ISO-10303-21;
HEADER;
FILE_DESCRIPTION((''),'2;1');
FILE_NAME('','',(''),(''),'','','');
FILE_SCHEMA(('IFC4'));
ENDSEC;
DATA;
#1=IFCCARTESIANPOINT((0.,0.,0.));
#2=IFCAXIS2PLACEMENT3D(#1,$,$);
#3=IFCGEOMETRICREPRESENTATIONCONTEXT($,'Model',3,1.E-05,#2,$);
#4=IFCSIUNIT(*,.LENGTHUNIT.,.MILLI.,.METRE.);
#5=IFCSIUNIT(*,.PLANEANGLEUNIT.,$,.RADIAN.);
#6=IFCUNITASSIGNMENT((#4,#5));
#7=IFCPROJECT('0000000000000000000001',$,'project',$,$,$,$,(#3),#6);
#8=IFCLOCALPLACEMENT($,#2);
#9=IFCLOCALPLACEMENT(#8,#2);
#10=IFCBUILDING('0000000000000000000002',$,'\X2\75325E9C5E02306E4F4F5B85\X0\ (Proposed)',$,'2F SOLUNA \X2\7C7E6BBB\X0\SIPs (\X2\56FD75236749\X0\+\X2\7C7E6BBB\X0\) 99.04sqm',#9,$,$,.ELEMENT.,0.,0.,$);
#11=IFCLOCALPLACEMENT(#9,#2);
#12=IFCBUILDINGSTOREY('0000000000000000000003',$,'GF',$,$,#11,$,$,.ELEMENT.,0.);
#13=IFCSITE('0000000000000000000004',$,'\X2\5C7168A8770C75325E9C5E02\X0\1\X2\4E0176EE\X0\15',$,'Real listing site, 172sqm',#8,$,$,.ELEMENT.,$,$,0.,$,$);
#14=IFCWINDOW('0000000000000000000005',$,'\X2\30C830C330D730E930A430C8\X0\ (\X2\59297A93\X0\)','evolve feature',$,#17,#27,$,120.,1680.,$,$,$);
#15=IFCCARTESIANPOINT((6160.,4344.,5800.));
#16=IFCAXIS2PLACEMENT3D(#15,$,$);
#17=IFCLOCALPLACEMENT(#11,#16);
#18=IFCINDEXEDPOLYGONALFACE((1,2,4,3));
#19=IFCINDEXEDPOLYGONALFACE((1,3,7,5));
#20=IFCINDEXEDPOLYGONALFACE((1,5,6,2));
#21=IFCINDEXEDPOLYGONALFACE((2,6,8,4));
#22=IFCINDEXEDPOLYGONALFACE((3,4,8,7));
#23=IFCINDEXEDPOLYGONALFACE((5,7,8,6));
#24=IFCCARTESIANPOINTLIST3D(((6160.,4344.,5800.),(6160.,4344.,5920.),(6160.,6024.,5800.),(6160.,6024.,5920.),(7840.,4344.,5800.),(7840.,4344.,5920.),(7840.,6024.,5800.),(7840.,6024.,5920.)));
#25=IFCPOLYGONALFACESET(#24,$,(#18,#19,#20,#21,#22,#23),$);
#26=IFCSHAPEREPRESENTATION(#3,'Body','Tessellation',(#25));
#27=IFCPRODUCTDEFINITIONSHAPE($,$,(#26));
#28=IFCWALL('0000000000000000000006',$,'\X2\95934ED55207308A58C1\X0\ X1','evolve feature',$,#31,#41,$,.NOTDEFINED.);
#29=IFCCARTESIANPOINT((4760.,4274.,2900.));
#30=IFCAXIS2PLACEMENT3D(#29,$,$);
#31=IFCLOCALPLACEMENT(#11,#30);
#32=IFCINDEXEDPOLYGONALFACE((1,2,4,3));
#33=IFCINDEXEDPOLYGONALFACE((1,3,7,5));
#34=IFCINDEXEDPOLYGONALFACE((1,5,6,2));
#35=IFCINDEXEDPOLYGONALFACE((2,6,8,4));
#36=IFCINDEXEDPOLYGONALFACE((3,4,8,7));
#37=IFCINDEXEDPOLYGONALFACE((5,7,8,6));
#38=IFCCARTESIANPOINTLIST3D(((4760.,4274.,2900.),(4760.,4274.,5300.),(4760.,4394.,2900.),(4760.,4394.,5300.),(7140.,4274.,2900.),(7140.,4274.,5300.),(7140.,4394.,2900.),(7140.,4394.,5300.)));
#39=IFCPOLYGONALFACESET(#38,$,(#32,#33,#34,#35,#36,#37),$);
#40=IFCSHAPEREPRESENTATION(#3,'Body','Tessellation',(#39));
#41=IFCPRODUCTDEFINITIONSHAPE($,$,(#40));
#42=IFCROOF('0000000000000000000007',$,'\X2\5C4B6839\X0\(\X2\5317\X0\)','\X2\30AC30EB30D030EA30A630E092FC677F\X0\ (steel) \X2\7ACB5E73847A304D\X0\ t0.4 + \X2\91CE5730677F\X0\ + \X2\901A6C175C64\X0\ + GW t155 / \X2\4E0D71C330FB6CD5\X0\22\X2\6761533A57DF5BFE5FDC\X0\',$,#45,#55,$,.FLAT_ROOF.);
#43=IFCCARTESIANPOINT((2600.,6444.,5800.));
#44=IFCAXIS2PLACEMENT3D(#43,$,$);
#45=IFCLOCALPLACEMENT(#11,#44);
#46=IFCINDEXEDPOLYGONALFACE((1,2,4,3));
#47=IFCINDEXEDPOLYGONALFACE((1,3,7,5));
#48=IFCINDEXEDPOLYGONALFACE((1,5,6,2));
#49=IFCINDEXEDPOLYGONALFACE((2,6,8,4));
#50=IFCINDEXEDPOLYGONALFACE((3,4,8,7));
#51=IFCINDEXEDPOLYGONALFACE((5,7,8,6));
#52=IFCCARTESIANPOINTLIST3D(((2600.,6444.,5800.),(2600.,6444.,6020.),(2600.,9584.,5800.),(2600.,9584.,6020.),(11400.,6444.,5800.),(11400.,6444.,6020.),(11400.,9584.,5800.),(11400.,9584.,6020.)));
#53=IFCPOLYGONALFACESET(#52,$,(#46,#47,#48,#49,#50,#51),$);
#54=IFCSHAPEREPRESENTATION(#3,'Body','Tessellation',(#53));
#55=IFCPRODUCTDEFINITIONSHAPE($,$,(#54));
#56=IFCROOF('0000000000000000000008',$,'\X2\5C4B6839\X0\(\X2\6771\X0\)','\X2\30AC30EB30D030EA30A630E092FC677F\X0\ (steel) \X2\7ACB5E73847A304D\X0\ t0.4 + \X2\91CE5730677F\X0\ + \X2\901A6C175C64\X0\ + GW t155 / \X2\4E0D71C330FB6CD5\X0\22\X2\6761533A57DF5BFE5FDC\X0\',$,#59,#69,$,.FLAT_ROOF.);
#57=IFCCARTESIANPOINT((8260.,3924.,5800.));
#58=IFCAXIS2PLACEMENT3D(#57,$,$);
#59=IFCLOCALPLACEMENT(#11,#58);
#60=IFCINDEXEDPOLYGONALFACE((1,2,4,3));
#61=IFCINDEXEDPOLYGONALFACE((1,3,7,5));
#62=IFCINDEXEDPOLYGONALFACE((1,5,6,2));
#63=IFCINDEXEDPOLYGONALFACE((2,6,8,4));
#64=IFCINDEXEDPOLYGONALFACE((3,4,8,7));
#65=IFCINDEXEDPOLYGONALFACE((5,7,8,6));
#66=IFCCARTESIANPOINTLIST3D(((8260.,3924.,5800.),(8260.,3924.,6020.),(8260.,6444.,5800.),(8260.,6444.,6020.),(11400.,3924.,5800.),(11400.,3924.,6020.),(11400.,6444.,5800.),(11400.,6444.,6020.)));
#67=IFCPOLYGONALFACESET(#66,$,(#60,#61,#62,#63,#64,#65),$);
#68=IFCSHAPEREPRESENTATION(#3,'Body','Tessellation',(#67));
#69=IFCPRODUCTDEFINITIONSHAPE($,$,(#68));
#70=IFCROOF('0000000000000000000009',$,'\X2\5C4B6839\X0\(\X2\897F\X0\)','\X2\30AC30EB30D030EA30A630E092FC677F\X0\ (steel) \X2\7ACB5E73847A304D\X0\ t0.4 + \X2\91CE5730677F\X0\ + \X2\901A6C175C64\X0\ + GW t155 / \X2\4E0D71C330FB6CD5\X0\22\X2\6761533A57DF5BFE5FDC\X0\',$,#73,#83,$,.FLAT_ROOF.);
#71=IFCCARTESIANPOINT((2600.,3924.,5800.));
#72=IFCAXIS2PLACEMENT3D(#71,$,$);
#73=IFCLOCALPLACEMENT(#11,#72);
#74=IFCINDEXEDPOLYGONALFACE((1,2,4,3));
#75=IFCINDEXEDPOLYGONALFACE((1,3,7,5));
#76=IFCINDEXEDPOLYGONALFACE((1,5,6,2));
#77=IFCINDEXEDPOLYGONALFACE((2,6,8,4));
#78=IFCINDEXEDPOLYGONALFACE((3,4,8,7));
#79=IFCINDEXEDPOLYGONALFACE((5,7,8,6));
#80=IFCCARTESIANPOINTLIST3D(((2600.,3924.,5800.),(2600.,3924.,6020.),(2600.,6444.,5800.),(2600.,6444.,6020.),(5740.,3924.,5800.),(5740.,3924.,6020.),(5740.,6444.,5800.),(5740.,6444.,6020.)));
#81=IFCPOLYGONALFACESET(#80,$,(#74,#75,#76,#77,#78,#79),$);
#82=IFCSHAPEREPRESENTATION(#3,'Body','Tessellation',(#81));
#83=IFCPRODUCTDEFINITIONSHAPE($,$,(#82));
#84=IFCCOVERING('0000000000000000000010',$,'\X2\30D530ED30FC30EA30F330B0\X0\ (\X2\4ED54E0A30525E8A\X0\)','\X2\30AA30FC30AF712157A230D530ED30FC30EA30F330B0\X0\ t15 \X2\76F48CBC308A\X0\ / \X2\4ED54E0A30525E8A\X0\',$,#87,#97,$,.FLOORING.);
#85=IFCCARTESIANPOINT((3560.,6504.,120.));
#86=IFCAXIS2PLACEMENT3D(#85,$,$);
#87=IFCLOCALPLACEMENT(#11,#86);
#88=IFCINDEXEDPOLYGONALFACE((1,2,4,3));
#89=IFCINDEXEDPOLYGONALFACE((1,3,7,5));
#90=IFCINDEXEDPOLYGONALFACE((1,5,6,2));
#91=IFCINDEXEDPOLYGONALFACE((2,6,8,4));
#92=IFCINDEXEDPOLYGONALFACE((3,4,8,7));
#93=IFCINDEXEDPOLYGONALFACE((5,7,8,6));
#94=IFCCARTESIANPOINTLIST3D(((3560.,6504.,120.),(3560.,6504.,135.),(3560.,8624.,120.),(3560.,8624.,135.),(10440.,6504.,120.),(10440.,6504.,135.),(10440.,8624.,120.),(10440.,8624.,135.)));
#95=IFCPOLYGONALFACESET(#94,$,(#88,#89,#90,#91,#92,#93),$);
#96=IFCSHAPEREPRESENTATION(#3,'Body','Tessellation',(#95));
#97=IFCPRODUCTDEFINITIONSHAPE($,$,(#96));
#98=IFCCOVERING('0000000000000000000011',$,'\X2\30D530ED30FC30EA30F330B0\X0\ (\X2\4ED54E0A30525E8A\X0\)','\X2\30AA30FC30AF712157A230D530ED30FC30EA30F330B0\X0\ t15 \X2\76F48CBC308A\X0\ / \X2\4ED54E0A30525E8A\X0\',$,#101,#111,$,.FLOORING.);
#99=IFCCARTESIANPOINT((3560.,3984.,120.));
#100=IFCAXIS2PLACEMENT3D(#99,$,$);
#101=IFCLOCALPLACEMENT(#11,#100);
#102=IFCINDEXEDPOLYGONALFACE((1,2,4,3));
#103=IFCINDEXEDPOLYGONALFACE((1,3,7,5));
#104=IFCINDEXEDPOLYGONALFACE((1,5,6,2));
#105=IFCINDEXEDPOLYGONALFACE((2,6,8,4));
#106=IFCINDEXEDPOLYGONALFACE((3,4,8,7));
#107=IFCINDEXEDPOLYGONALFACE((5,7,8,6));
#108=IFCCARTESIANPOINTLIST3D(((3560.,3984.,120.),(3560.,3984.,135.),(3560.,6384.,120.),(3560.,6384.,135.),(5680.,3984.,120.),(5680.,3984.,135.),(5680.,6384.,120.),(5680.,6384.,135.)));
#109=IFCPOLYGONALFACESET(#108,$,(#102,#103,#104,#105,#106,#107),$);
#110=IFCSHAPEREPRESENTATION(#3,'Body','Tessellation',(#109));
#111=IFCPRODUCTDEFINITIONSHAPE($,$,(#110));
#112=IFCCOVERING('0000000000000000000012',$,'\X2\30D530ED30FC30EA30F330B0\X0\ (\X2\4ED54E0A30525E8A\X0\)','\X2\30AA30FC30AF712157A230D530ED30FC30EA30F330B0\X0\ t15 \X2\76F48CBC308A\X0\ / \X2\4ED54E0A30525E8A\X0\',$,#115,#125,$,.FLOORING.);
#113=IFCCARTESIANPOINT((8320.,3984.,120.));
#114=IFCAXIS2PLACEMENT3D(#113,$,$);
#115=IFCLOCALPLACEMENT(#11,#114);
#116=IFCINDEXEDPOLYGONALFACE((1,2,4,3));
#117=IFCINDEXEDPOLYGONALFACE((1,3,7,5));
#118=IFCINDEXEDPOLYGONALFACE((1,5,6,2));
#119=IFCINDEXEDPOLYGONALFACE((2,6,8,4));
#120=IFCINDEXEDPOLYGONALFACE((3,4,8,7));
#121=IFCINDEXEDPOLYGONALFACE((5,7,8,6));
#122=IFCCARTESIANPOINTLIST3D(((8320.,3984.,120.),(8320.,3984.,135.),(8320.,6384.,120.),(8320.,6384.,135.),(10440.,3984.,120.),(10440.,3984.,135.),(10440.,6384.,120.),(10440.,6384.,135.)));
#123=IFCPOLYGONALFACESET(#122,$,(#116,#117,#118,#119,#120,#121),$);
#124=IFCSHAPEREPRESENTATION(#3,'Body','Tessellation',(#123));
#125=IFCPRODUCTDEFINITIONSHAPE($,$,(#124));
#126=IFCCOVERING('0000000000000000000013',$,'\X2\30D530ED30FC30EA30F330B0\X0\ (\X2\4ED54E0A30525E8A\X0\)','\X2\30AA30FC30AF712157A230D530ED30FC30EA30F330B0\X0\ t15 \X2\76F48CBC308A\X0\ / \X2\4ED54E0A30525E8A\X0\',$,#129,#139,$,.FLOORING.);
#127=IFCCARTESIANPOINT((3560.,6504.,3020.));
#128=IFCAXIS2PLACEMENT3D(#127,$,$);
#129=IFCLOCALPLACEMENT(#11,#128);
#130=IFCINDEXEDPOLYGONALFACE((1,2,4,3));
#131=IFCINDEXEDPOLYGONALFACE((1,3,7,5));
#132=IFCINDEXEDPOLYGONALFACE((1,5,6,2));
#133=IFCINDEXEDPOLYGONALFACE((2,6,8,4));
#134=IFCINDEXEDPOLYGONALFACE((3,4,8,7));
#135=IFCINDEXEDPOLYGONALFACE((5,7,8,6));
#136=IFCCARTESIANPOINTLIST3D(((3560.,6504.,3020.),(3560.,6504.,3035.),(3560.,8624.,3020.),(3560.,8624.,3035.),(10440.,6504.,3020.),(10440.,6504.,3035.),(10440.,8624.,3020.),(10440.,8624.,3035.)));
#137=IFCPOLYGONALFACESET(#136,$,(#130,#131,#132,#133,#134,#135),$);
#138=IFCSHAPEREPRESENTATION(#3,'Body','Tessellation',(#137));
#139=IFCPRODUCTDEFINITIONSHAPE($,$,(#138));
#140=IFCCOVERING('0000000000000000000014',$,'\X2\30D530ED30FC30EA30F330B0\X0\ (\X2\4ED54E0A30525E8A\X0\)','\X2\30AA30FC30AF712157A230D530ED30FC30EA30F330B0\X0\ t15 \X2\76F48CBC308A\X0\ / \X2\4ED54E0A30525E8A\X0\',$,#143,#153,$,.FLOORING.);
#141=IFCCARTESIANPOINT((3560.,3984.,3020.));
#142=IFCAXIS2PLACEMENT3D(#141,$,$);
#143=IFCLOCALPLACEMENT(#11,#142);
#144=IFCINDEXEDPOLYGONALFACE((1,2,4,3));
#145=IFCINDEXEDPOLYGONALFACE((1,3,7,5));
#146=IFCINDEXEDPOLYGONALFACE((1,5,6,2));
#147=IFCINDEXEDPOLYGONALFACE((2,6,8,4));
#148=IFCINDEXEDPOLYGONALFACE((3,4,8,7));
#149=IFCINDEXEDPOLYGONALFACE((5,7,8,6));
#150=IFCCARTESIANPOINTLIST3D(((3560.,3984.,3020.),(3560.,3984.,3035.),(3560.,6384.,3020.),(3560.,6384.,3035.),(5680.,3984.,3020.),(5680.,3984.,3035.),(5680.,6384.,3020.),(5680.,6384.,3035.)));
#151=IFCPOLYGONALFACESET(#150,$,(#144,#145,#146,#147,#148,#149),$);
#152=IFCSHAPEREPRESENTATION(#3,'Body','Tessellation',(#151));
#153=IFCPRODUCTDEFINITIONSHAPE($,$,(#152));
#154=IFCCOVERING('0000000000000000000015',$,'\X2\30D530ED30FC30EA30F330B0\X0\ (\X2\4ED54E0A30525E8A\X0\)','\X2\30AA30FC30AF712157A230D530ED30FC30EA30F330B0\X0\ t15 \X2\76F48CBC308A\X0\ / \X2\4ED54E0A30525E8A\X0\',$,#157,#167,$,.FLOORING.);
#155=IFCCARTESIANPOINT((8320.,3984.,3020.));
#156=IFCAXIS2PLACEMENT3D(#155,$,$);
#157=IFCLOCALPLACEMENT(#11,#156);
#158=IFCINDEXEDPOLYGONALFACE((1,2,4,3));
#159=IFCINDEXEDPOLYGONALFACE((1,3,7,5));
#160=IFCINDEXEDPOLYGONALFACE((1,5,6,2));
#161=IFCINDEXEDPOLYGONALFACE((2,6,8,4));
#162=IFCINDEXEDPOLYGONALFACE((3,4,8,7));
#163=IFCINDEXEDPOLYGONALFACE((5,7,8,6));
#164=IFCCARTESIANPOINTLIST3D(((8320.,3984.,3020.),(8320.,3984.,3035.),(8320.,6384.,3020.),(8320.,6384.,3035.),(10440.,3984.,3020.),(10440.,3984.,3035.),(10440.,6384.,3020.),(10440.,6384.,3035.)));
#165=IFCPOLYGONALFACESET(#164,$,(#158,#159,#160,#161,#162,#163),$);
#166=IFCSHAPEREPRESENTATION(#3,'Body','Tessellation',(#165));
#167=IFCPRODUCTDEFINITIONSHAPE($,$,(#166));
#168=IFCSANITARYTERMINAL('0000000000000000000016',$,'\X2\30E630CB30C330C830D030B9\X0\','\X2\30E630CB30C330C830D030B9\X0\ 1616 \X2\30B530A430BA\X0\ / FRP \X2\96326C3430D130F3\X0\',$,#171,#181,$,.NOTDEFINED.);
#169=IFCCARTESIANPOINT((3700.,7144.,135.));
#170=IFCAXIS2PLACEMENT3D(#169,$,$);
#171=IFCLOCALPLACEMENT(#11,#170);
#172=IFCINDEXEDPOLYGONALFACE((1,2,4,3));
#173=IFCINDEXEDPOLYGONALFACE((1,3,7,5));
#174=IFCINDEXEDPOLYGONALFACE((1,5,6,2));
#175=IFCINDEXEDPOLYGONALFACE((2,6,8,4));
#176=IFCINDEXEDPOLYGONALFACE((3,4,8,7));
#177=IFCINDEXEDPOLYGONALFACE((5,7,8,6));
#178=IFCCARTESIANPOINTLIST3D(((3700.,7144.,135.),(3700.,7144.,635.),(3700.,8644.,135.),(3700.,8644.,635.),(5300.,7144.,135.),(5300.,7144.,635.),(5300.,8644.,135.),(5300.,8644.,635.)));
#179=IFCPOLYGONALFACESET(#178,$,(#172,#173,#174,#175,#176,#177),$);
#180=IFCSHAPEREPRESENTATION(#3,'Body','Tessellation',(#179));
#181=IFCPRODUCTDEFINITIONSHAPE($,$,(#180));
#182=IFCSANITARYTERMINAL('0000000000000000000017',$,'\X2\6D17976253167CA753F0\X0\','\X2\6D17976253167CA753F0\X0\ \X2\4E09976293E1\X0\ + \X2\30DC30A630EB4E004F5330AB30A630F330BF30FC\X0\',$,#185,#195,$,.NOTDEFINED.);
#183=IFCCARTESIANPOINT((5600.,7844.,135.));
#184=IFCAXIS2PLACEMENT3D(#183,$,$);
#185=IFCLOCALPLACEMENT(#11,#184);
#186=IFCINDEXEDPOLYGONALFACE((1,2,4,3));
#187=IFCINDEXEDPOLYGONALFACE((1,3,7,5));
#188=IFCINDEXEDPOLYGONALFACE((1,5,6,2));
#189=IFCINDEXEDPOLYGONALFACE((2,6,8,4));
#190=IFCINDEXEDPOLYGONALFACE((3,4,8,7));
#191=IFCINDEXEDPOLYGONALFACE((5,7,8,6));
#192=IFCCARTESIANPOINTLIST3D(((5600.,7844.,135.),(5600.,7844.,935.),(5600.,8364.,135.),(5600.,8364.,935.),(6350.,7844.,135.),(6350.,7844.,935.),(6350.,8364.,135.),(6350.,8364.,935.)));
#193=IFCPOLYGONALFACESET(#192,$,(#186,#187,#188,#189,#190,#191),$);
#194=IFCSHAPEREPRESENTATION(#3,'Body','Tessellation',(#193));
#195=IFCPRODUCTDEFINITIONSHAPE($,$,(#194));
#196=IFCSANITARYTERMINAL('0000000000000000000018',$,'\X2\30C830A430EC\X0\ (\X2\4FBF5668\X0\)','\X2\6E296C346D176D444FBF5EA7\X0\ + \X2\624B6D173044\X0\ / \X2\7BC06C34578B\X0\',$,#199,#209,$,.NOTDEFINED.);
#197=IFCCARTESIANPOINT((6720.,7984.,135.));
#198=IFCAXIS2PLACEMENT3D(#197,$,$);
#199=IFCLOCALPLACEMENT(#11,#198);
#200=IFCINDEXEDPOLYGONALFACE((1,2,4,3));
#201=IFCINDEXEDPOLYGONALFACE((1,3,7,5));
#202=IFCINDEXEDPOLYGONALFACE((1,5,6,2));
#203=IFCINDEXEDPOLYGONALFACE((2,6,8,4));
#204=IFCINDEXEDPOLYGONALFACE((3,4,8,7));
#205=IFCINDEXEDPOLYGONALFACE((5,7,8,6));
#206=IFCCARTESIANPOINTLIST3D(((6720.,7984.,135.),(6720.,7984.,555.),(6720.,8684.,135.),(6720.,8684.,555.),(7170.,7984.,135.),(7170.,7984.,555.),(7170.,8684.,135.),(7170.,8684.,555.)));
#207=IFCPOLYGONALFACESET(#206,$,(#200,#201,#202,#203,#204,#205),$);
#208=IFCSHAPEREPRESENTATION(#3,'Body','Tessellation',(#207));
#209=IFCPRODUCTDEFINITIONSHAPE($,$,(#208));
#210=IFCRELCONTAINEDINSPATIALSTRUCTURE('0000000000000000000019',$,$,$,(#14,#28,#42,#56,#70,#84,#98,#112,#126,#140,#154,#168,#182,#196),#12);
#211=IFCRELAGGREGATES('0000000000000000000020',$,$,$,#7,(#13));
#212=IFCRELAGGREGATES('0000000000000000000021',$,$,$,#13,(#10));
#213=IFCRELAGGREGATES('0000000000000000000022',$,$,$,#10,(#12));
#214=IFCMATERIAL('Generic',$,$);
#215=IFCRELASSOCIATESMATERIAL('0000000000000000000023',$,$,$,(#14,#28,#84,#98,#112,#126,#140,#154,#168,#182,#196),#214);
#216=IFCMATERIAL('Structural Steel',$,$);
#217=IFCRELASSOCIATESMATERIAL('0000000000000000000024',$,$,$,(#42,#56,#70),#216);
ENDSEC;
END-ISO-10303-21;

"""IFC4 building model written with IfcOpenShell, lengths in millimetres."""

from ifc_helpers import new_model, si_unit, frame, frame_2d, origin, place, context, project, spatial, rectangle, extrude, material, element, save


model = new_model("IFC4")

# Units and contexts
model_context = context("Model", 3, precision=1e-05, world=origin())
ifc_project = project(units=[si_unit("LENGTHUNIT", "METRE", prefix="MILLI"), si_unit("PLANEANGLEUNIT", "RADIAN")], contexts=[model_context])

# Site, building, storey
site_placement = place(None, origin())
site = spatial("IfcSite", under=ifc_project, at=site_placement, Name="山梨県甲府市1丁目15", ObjectType="Real listing site, 172sqm", CompositionType="ELEMENT", RefElevation=0.0)
building_placement = place(site_placement, origin())
building = spatial("IfcBuilding", under=site, at=building_placement, Name="甲府市の住宅 (Proposed)", ObjectType="2F SOLUNA 籾殻SIPs (国産杉+籾殻) 99.04sqm", CompositionType="ELEMENT", ElevationOfRefHeight=0.0, ElevationOfTerrain=0.0)
storey_placement = place(building_placement, origin())
storey = spatial("IfcBuildingStorey", under=building, at=storey_placement, Name="GF", CompositionType="ELEMENT", Elevation=0.0)

# Window
ifc_material_1 = material(Name="Generic")
window_1_placement = place(storey_placement, frame((6160.0, 4344.0, 5800.0)))
element("IfcWindow", 1, at=window_1_placement, inside=storey, material=ifc_material_1, Name="トップライト (天窓)", Description="evolve feature", OverallHeight=120.0, OverallWidth=1680.0, context=model_context, shape_type="SweptSolid", body=[
    extrude(rectangle(XDim=1680.0, YDim=1680.0, at=frame_2d((840.0, 840.0))), frame((6160.0, 4344.0, 5800.0)), (0.0, 0.0, 1.0), 120.0),
])

# Wall
wall_1_placement = place(storey_placement, frame((4760.0, 4274.0, 2900.0)))
element("IfcWall", 2, at=wall_1_placement, inside=storey, material=ifc_material_1, Name="間仕切り壁 X1", Description="evolve feature", PredefinedType="NOTDEFINED", context=model_context, shape_type="SweptSolid", body=[
    extrude(rectangle(XDim=2380.0, YDim=120.0, at=frame_2d((1190.0, 60.0))), frame((4760.0, 4274.0, 2900.0)), (0.0, 0.0, 1.0), 2400.0),
])

# Roofs
ifc_material_2 = material(Name="Structural Steel")
roof_1_placement = place(storey_placement, frame((2600.0, 6444.0, 5800.0)))
element("IfcRoof", 3, at=roof_1_placement, inside=storey, material=ifc_material_2, Name="屋根(北)", Description="ガルバリウム鋼板 (steel) 立平葺き t0.4 + 野地板 + 通気層 + GW t155 / 不燃・法22条区域対応", PredefinedType="FLAT_ROOF", context=model_context, shape_type="SweptSolid", body=[
    extrude(rectangle(XDim=8800.0, YDim=3140.0, at=frame_2d((4400.0, 1570.0))), frame((2600.0, 6444.0, 5800.0)), (0.0, 0.0, 1.0), 220.0),
])
roof_2_placement = place(storey_placement, frame((8260.0, 3924.0, 5800.0)))
element("IfcRoof", 4, at=roof_2_placement, inside=storey, material=ifc_material_2, Name="屋根(東)", Description="ガルバリウム鋼板 (steel) 立平葺き t0.4 + 野地板 + 通気層 + GW t155 / 不燃・法22条区域対応", PredefinedType="FLAT_ROOF", context=model_context, shape_type="SweptSolid", body=[
    extrude(rectangle(XDim=3140.0, YDim=2520.0, at=frame_2d((1570.0, 1260.0))), frame((8260.0, 3924.0, 5800.0)), (0.0, 0.0, 1.0), 220.0),
])
roof_3_placement = place(storey_placement, frame((2600.0, 3924.0, 5800.0)))
element("IfcRoof", 5, at=roof_3_placement, inside=storey, material=ifc_material_2, Name="屋根(西)", Description="ガルバリウム鋼板 (steel) 立平葺き t0.4 + 野地板 + 通気層 + GW t155 / 不燃・法22条区域対応", PredefinedType="FLAT_ROOF", context=model_context, shape_type="SweptSolid", body=[
    extrude(rectangle(XDim=3140.0, YDim=2520.0, at=frame_2d((1570.0, 1260.0))), frame((2600.0, 3924.0, 5800.0)), (0.0, 0.0, 1.0), 220.0),
])

# Coverings
covering_1_placement = place(storey_placement, frame((3560.0, 6504.0, 120.0)))
element("IfcCovering", 6, at=covering_1_placement, inside=storey, material=ifc_material_1, Name="フローリング (仕上げ床)", Description="オーク無垢フローリング t15 直貼り / 仕上げ床", PredefinedType="FLOORING", context=model_context, shape_type="SweptSolid", body=[
    extrude(rectangle(XDim=6880.0, YDim=2120.0, at=frame_2d((3440.0, 1060.0))), frame((3560.0, 6504.0, 120.0)), (0.0, 0.0, 1.0), 15.0),
])
covering_2_placement = place(storey_placement, frame((3560.0, 3984.0, 120.0)))
element("IfcCovering", 7, at=covering_2_placement, inside=storey, material=ifc_material_1, Name="フローリング (仕上げ床)", Description="オーク無垢フローリング t15 直貼り / 仕上げ床", PredefinedType="FLOORING", context=model_context, shape_type="SweptSolid", body=[
    extrude(rectangle(XDim=2120.0, YDim=2400.0, at=frame_2d((1060.0, 1200.0))), frame((3560.0, 3984.0, 120.0)), (0.0, 0.0, 1.0), 15.0),
])
covering_3_placement = place(storey_placement, frame((8320.0, 3984.0, 120.0)))
element("IfcCovering", 8, at=covering_3_placement, inside=storey, material=ifc_material_1, Name="フローリング (仕上げ床)", Description="オーク無垢フローリング t15 直貼り / 仕上げ床", PredefinedType="FLOORING", context=model_context, shape_type="SweptSolid", body=[
    extrude(rectangle(XDim=2120.0, YDim=2400.0, at=frame_2d((1060.0, 1200.0))), frame((8320.0, 3984.0, 120.0)), (0.0, 0.0, 1.0), 15.0),
])
covering_4_placement = place(storey_placement, frame((3560.0, 6504.0, 3020.0)))
element("IfcCovering", 9, at=covering_4_placement, inside=storey, material=ifc_material_1, Name="フローリング (仕上げ床)", Description="オーク無垢フローリング t15 直貼り / 仕上げ床", PredefinedType="FLOORING", context=model_context, shape_type="SweptSolid", body=[
    extrude(rectangle(XDim=6880.0, YDim=2120.0, at=frame_2d((3440.0, 1060.0))), frame((3560.0, 6504.0, 3020.0)), (0.0, 0.0, 1.0), 15.0),
])
covering_5_placement = place(storey_placement, frame((3560.0, 3984.0, 3020.0)))
element("IfcCovering", 10, at=covering_5_placement, inside=storey, material=ifc_material_1, Name="フローリング (仕上げ床)", Description="オーク無垢フローリング t15 直貼り / 仕上げ床", PredefinedType="FLOORING", context=model_context, shape_type="SweptSolid", body=[
    extrude(rectangle(XDim=2120.0, YDim=2400.0, at=frame_2d((1060.0, 1200.0))), frame((3560.0, 3984.0, 3020.0)), (0.0, 0.0, 1.0), 15.0),
])
covering_6_placement = place(storey_placement, frame((8320.0, 3984.0, 3020.0)))
element("IfcCovering", 11, at=covering_6_placement, inside=storey, material=ifc_material_1, Name="フローリング (仕上げ床)", Description="オーク無垢フローリング t15 直貼り / 仕上げ床", PredefinedType="FLOORING", context=model_context, shape_type="SweptSolid", body=[
    extrude(rectangle(XDim=2120.0, YDim=2400.0, at=frame_2d((1060.0, 1200.0))), frame((8320.0, 3984.0, 3020.0)), (0.0, 0.0, 1.0), 15.0),
])

# Sanitary terminals
sanitary_terminal_1_placement = place(storey_placement, frame((3700.0, 7144.0, 135.0)))
element("IfcSanitaryTerminal", 12, at=sanitary_terminal_1_placement, inside=storey, material=ifc_material_1, Name="ユニットバス", Description="ユニットバス 1616 サイズ / FRP 防水パン", PredefinedType="NOTDEFINED", context=model_context, shape_type="SweptSolid", body=[
    extrude(rectangle(XDim=1600.0, YDim=1500.0, at=frame_2d((800.0, 750.0))), frame((3700.0, 7144.0, 135.0)), (0.0, 0.0, 1.0), 500.0),
])
sanitary_terminal_2_placement = place(storey_placement, frame((5600.0, 7844.0, 135.0)))
element("IfcSanitaryTerminal", 13, at=sanitary_terminal_2_placement, inside=storey, material=ifc_material_1, Name="洗面化粧台", Description="洗面化粧台 三面鏡 + ボウル一体カウンター", PredefinedType="NOTDEFINED", context=model_context, shape_type="SweptSolid", body=[
    extrude(rectangle(XDim=750.0, YDim=520.0, at=frame_2d((375.0, 260.0))), frame((5600.0, 7844.0, 135.0)), (0.0, 0.0, 1.0), 800.0),
])
sanitary_terminal_3_placement = place(storey_placement, frame((6720.0, 7984.0, 135.0)))
element("IfcSanitaryTerminal", 14, at=sanitary_terminal_3_placement, inside=storey, material=ifc_material_1, Name="トイレ (便器)", Description="温水洗浄便座 + 手洗い / 節水型", PredefinedType="NOTDEFINED", context=model_context, shape_type="SweptSolid", body=[
    extrude(rectangle(XDim=450.0, YDim=700.0, at=frame_2d((225.0, 350.0))), frame((6720.0, 7984.0, 135.0)), (0.0, 0.0, 1.0), 420.0),
])

save(model, "model.ifc")
